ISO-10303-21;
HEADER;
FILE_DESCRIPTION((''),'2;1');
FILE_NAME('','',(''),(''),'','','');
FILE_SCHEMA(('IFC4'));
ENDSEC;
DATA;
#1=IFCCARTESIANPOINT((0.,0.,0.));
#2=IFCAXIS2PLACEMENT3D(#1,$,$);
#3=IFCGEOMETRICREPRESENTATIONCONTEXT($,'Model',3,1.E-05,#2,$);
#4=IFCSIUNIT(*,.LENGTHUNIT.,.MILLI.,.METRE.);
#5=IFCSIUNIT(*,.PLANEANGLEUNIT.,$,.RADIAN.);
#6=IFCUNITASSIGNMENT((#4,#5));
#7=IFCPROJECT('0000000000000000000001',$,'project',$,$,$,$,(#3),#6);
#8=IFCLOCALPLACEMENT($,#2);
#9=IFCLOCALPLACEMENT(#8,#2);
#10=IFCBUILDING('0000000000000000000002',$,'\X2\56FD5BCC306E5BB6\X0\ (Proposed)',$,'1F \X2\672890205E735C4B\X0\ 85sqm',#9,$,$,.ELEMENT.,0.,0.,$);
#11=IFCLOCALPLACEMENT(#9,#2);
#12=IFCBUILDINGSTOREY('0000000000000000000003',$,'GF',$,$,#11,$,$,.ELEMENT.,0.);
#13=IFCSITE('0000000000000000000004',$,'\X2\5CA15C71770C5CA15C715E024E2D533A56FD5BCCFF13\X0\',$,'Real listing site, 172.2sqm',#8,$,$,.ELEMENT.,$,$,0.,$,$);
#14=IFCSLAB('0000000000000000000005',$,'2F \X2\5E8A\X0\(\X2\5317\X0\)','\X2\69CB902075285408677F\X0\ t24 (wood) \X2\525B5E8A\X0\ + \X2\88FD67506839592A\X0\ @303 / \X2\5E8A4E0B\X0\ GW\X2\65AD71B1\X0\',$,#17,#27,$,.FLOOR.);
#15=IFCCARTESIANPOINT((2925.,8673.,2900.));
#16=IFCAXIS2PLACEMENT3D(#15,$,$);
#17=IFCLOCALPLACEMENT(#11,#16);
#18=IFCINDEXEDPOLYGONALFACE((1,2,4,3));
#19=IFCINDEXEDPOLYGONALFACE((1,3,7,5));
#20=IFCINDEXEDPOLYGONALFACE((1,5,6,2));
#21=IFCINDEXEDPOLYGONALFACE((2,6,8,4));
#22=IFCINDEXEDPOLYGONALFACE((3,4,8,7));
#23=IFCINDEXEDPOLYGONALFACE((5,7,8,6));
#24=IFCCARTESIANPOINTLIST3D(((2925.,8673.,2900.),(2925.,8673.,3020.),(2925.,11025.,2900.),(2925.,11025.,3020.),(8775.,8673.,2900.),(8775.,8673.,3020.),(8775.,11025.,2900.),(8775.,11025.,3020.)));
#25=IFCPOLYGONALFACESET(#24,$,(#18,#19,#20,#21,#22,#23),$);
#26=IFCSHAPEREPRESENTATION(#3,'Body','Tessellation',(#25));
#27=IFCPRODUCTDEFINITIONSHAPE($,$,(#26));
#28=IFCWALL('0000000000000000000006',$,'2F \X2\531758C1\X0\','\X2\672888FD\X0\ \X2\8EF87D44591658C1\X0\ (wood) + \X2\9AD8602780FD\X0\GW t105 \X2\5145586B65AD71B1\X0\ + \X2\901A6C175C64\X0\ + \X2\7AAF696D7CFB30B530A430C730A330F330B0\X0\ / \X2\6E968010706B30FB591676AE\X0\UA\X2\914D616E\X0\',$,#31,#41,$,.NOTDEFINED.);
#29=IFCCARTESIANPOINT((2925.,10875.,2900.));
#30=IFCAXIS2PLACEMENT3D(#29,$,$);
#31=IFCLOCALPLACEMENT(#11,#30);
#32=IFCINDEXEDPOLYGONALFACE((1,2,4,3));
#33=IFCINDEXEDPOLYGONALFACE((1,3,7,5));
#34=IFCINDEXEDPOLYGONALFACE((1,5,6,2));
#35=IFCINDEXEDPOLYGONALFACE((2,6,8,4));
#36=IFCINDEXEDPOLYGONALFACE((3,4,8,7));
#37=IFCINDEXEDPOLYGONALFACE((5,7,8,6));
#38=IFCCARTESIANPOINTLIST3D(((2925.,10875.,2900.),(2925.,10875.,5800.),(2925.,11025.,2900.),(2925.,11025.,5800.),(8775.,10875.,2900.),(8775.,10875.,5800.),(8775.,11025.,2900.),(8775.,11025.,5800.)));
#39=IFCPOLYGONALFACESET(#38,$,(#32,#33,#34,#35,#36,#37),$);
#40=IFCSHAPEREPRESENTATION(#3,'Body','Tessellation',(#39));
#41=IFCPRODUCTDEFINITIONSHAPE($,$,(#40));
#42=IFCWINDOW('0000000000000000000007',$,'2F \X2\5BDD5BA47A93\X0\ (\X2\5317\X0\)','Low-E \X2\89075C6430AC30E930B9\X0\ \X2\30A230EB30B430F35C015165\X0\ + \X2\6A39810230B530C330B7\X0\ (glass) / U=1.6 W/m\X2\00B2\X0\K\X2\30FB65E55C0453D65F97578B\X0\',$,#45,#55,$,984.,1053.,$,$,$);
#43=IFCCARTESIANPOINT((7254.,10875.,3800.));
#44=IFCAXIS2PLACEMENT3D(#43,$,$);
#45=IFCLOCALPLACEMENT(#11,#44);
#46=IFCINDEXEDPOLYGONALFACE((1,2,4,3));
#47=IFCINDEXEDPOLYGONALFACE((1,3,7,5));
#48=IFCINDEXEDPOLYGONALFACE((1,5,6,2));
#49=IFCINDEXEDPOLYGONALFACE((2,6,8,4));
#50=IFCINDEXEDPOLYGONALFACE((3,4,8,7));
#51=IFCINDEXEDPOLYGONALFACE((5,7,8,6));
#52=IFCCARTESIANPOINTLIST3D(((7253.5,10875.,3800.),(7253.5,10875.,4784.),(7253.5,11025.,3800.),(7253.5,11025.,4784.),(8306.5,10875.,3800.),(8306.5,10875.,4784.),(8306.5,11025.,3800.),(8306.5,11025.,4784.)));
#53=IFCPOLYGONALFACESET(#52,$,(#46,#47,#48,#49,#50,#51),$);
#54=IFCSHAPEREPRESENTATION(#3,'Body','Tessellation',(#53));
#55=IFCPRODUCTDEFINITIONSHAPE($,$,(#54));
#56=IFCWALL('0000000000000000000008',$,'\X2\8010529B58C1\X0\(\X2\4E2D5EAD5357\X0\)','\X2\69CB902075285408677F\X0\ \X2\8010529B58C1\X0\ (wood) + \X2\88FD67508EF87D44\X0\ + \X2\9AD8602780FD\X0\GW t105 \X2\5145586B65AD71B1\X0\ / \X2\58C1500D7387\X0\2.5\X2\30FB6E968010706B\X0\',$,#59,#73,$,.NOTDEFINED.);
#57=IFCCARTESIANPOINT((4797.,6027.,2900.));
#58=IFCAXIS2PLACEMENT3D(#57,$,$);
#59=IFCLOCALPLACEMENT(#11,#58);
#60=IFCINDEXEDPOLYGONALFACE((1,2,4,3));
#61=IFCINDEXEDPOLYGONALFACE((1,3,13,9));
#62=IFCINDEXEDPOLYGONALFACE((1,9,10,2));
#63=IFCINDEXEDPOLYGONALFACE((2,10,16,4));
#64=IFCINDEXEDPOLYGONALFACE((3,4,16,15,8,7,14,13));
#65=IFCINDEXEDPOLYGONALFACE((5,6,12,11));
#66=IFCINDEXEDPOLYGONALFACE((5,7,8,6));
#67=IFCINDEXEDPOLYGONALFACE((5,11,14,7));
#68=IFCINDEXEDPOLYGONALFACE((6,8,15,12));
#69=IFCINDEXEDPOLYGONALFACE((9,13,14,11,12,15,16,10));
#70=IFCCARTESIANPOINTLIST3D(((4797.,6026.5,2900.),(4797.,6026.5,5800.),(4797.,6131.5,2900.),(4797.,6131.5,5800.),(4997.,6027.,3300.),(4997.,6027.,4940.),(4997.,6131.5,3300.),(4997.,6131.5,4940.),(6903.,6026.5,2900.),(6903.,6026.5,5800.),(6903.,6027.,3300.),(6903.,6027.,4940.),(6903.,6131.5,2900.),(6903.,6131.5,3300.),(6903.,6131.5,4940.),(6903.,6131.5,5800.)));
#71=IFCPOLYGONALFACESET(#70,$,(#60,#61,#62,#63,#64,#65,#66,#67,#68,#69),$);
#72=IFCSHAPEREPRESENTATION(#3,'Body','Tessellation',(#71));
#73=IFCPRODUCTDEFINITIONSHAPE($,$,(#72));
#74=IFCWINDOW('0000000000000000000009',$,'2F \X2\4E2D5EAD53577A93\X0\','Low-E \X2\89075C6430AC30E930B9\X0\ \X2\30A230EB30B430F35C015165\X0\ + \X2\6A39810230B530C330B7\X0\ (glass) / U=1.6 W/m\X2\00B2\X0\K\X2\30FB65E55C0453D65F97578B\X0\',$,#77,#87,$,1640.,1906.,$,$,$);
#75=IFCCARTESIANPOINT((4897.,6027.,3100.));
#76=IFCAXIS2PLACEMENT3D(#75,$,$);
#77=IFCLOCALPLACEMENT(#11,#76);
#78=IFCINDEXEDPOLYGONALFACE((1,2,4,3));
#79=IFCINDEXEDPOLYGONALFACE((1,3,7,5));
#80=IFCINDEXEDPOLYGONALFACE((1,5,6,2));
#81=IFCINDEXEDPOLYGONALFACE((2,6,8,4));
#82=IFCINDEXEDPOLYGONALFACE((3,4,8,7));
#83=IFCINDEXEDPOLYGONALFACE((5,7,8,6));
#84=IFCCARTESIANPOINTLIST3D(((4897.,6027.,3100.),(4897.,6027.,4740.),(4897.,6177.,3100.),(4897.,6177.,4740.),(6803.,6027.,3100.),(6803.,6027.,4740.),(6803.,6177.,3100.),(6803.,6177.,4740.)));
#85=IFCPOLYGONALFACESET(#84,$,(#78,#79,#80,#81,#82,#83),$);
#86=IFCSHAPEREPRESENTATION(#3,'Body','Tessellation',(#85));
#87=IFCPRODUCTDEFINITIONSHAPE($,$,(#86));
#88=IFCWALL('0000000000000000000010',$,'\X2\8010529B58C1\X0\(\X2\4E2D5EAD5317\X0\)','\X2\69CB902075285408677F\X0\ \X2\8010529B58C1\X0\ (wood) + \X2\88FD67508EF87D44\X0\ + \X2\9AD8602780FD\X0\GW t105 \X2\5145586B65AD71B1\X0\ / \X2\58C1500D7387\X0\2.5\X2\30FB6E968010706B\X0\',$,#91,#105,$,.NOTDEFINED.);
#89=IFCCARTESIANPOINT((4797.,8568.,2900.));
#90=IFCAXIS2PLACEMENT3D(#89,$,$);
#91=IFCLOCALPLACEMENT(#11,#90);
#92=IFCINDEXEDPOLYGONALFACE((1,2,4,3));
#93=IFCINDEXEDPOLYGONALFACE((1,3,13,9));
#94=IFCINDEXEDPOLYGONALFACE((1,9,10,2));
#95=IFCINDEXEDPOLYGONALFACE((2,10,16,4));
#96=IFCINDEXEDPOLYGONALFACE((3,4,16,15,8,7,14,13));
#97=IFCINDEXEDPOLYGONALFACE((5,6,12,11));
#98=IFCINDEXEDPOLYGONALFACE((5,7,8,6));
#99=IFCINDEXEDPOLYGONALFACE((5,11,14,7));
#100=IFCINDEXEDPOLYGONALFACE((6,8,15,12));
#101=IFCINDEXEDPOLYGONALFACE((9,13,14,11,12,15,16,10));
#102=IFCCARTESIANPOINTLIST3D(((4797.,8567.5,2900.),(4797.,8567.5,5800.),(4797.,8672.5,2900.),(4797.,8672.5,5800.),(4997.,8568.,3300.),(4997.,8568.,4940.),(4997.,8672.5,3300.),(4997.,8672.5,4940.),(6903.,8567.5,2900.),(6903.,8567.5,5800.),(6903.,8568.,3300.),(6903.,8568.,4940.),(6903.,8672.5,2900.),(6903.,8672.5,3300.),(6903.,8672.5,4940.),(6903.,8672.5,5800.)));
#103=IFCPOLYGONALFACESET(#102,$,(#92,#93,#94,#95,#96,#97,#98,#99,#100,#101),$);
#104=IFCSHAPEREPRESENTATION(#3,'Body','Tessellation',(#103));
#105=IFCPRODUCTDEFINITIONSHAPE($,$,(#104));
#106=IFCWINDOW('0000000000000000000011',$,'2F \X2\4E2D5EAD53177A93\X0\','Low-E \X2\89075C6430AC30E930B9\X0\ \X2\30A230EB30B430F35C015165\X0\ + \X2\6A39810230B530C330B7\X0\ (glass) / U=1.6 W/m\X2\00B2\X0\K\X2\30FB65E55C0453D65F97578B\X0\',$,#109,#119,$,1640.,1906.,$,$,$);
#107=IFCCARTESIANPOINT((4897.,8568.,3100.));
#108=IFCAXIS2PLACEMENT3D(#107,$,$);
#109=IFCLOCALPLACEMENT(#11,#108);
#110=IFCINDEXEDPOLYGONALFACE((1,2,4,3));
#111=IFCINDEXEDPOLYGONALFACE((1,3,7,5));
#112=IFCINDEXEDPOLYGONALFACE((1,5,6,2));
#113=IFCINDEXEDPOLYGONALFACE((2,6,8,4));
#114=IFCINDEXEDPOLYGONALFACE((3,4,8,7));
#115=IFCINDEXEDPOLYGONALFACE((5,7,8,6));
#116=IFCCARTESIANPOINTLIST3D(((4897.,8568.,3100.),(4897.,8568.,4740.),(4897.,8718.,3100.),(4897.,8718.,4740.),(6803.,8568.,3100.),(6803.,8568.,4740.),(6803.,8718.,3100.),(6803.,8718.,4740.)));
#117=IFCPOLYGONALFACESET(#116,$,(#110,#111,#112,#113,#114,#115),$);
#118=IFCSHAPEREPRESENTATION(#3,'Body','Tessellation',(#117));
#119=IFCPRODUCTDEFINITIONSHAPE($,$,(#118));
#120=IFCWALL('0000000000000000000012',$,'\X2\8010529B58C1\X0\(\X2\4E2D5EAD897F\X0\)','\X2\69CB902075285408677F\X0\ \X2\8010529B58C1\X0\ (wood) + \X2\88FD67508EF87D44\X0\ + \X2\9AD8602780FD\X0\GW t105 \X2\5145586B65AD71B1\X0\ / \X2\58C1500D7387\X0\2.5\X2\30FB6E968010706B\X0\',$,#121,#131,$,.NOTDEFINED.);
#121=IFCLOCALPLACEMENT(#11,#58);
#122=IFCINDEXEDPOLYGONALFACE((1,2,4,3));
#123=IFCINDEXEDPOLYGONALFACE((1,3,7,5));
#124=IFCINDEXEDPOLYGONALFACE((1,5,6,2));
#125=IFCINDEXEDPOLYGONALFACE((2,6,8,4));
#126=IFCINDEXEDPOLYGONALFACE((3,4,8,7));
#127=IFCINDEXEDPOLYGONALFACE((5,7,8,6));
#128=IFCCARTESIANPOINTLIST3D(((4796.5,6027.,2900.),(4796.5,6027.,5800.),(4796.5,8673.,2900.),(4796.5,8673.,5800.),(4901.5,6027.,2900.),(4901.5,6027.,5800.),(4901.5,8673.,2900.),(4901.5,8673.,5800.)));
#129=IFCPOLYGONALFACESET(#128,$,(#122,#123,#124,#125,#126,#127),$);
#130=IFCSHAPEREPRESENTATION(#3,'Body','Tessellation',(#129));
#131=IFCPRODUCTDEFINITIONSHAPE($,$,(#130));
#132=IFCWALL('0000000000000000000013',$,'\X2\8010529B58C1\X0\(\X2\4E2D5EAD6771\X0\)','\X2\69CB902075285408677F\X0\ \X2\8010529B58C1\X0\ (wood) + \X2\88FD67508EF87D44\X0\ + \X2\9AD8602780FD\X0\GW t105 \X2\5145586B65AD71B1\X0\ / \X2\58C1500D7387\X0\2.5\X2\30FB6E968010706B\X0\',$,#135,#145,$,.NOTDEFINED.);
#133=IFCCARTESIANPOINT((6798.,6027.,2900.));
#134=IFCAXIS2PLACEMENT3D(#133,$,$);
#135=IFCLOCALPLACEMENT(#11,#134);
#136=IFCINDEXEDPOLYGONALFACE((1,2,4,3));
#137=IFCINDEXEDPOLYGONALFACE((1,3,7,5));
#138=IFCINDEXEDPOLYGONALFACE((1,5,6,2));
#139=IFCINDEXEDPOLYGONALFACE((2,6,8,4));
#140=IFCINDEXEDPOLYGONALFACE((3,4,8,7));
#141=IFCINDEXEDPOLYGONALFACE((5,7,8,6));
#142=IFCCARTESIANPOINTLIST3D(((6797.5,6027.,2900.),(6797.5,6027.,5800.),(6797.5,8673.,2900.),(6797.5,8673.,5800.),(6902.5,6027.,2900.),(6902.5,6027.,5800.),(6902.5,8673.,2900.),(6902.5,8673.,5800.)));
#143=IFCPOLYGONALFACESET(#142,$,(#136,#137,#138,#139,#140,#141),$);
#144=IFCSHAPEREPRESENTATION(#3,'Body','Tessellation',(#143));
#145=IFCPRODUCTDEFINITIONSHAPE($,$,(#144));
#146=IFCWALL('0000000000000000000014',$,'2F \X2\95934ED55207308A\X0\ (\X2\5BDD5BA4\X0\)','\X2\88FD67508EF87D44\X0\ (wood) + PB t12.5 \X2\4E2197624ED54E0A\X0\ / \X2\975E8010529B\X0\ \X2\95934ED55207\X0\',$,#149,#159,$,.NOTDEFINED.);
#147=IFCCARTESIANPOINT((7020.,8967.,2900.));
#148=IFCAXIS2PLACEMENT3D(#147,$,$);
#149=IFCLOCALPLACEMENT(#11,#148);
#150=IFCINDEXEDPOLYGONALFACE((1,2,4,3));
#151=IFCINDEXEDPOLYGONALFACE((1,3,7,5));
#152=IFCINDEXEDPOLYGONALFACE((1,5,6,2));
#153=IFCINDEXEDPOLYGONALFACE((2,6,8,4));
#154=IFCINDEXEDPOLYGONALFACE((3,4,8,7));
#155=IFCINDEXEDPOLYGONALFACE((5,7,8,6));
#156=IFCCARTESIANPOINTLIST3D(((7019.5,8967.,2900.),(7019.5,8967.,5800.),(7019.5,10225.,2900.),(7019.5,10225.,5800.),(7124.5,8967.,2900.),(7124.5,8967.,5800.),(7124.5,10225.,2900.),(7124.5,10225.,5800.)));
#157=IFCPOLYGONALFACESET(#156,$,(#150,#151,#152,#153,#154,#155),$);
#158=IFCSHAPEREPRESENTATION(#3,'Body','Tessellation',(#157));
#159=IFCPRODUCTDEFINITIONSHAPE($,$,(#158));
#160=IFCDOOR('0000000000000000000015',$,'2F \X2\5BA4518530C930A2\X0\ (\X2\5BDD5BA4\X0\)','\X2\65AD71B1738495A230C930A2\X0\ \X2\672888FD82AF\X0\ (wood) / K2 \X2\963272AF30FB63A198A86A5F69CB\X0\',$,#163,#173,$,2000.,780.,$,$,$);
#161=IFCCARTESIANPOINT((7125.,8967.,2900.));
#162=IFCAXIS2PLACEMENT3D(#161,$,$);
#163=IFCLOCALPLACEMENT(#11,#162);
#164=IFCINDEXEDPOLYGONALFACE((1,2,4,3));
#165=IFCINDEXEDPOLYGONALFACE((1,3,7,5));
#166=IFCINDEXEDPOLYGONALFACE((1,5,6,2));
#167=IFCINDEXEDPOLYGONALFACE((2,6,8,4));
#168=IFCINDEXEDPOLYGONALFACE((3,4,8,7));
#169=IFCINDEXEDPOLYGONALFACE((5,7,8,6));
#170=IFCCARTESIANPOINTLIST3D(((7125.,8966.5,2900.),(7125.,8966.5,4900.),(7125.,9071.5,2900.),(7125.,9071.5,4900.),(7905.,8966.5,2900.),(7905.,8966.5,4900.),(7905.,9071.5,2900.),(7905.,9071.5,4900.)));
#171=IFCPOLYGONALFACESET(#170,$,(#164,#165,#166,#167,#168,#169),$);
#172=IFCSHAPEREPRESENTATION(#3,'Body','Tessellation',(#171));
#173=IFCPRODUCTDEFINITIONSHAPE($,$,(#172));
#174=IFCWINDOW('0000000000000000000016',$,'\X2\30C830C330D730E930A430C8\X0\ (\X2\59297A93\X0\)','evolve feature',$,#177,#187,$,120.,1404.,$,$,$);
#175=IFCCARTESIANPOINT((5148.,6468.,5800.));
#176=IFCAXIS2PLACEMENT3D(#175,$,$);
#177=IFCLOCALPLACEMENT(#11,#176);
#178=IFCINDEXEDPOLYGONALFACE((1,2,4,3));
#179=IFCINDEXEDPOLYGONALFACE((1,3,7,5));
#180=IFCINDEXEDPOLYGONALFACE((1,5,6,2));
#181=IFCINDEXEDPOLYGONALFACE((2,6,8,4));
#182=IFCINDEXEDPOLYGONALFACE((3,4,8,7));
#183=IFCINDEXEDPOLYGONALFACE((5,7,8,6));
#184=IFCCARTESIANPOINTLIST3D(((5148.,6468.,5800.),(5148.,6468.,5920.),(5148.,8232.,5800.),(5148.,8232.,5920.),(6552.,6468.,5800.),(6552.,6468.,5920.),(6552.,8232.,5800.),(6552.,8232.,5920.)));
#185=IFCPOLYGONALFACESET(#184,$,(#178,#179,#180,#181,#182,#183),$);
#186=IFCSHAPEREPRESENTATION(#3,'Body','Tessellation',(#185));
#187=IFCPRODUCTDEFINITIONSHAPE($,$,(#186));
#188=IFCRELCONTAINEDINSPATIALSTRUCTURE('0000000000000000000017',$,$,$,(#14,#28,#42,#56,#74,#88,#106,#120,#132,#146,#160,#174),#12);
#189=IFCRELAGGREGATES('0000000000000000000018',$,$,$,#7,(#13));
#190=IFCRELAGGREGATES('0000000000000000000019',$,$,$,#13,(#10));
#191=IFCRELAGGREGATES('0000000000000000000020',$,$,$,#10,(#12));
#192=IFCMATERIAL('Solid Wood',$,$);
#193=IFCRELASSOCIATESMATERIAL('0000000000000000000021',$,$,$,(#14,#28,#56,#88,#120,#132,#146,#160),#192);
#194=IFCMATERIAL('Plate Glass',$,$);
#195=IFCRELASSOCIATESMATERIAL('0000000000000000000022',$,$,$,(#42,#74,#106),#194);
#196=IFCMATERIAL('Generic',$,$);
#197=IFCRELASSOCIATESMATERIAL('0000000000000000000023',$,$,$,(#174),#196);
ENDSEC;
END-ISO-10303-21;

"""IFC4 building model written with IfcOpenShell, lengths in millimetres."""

from ifc_helpers import new_model, si_unit, frame, frame_2d, origin, place, context, project, spatial, rectangle, extrude, material, element, fill, save


model = new_model("IFC4")

# Units and contexts
model_context = context("Model", 3, precision=1e-05, world=origin())
ifc_project = project(units=[si_unit("LENGTHUNIT", "METRE", prefix="MILLI"), si_unit("PLANEANGLEUNIT", "RADIAN")], contexts=[model_context])

# Site, building, storey
site_placement = place(None, origin())
site = spatial("IfcSite", under=ifc_project, at=site_placement, Name="岡山県岡山市中区国富３", ObjectType="Real listing site, 172.2sqm", CompositionType="ELEMENT", RefElevation=0.0)
building_placement = place(site_placement, origin())
building = spatial("IfcBuilding", under=site, at=building_placement, Name="国富の家 (Proposed)", ObjectType="1F 木造平屋 85sqm", CompositionType="ELEMENT", ElevationOfRefHeight=0.0, ElevationOfTerrain=0.0)
storey_placement = place(building_placement, origin())
storey = spatial("IfcBuildingStorey", under=building, at=storey_placement, Name="GF", CompositionType="ELEMENT", Elevation=0.0)

# Slab
ifc_material_1 = material(Name="Solid Wood")
slab_placement = place(storey_placement, frame((2925.0, 8673.0, 2900.0)))
element("IfcSlab", 1, at=slab_placement, inside=storey, material=ifc_material_1, Name="2F 床(北)", Description="構造用合板 t24 (wood) 剛床 + 製材根太 @303 / 床下 GW断熱", PredefinedType="FLOOR", context=model_context, shape_type="SweptSolid", body=[
    extrude(rectangle(XDim=5850.0, YDim=2352.0, at=frame_2d((2925.0, 1176.0))), frame((2925.0, 8673.0, 2900.0)), (0.0, 0.0, 1.0), 120.0),
])

# Walls, openings, windows
wall_1_placement = place(storey_placement, frame((2925.0, 10875.0, 2900.0)))
wall_1 = element("IfcWall", 2, at=wall_1_placement, inside=storey, material=ifc_material_1, Name="2F 北壁", Description="木製 軸組外壁 (wood) + 高性能GW t105 充填断熱 + 通気層 + 窯業系サイディング / 準耐火・外皮UA配慮", PredefinedType="NOTDEFINED", context=model_context, shape_type="SweptSolid", body=[
    extrude(rectangle(XDim=5850.0, YDim=150.0, at=frame_2d((2925.0, 75.0))), frame((2925.0, 10875.0, 2900.0)), (0.0, 0.0, 1.0), 2900.0),
])
opening_1_placement = place(storey_placement, frame((7254.0, 10875.0, 3800.0)))
opening_1 = element("IfcOpeningElement", 3, at=opening_1_placement, cuts=wall_1, PredefinedType="NOTDEFINED", context=model_context, shape_type="SweptSolid", body=[
    extrude(rectangle(XDim=1053.0, YDim=150.0, at=frame_2d((526.0, 75.0))), frame((7254.0, 10875.0, 3800.0)), (0.0, 0.0, 1.0), 984.0),
])
ifc_material_2 = material(Name="Plate Glass")
window_1_placement = place(storey_placement, frame((7254.0, 10875.0, 3800.0)))
window_1 = element("IfcWindow", 4, at=window_1_placement, inside=storey, material=ifc_material_2, Name="2F 寝室窓 (北)", Description="Low-E 複層ガラス アルゴン封入 + 樹脂サッシ (glass) / U=1.6 W/m²K・日射取得型", OverallHeight=984.0, OverallWidth=1053.0, context=model_context, shape_type="SweptSolid", body=[
    extrude(rectangle(XDim=1053.0, YDim=150.0, at=frame_2d((526.0, 75.0))), frame((7254.0, 10875.0, 3800.0)), (0.0, 0.0, 1.0), 984.0),
])
fill(opening_1, window_1)
wall_2_placement = place(storey_placement, frame((4797.0, 6027.0, 2900.0)))
wall_2 = element("IfcWall", 5, at=wall_2_placement, inside=storey, material=ifc_material_1, Name="耐力壁(中庭南)", Description="構造用合板 耐力壁 (wood) + 製材軸組 + 高性能GW t105 充填断熱 / 壁倍率2.5・準耐火", PredefinedType="NOTDEFINED", context=model_context, shape_type="SweptSolid", body=[
    extrude(rectangle(XDim=2106.0, YDim=105.0, at=frame_2d((1053.0, 52.0))), frame((4797.0, 6027.0, 2900.0)), (0.0, 0.0, 1.0), 2900.0),
])
opening_2_placement = place(storey_placement, frame((4897.0, 6027.0, 3100.0)))
opening_2 = element("IfcOpeningElement", 6, at=opening_2_placement, cuts=wall_2, PredefinedType="NOTDEFINED", context=model_context, shape_type="SweptSolid", body=[
    extrude(rectangle(XDim=1906.0, YDim=150.0, at=frame_2d((953.0, 75.0))), frame((4897.0, 6027.0, 3100.0)), (0.0, 0.0, 1.0), 1640.0),
])
window_2_placement = place(storey_placement, frame((4897.0, 6027.0, 3100.0)))
window_2 = element("IfcWindow", 7, at=window_2_placement, inside=storey, material=ifc_material_2, Name="2F 中庭南窓", Description="Low-E 複層ガラス アルゴン封入 + 樹脂サッシ (glass) / U=1.6 W/m²K・日射取得型", OverallHeight=1640.0, OverallWidth=1906.0, context=model_context, shape_type="SweptSolid", body=[
    extrude(rectangle(XDim=1906.0, YDim=150.0, at=frame_2d((953.0, 75.0))), frame((4897.0, 6027.0, 3100.0)), (0.0, 0.0, 1.0), 1640.0),
])
fill(opening_2, window_2)
wall_3_placement = place(storey_placement, frame((4797.0, 8568.0, 2900.0)))
wall_3 = element("IfcWall", 8, at=wall_3_placement, inside=storey, material=ifc_material_1, Name="耐力壁(中庭北)", Description="構造用合板 耐力壁 (wood) + 製材軸組 + 高性能GW t105 充填断熱 / 壁倍率2.5・準耐火", PredefinedType="NOTDEFINED", context=model_context, shape_type="SweptSolid", body=[
    extrude(rectangle(XDim=2106.0, YDim=105.0, at=frame_2d((1053.0, 52.0))), frame((4797.0, 8568.0, 2900.0)), (0.0, 0.0, 1.0), 2900.0),
])
opening_3_placement = place(storey_placement, frame((4897.0, 8568.0, 3100.0)))
opening_3 = element("IfcOpeningElement", 9, at=opening_3_placement, cuts=wall_3, PredefinedType="NOTDEFINED", context=model_context, shape_type="SweptSolid", body=[
    extrude(rectangle(XDim=1906.0, YDim=150.0, at=frame_2d((953.0, 75.0))), frame((4897.0, 8568.0, 3100.0)), (0.0, 0.0, 1.0), 1640.0),
])
window_3_placement = place(storey_placement, frame((4897.0, 8568.0, 3100.0)))
window_3 = element("IfcWindow", 10, at=window_3_placement, inside=storey, material=ifc_material_2, Name="2F 中庭北窓", Description="Low-E 複層ガラス アルゴン封入 + 樹脂サッシ (glass) / U=1.6 W/m²K・日射取得型", OverallHeight=1640.0, OverallWidth=1906.0, context=model_context, shape_type="SweptSolid", body=[
    extrude(rectangle(XDim=1906.0, YDim=150.0, at=frame_2d((953.0, 75.0))), frame((4897.0, 8568.0, 3100.0)), (0.0, 0.0, 1.0), 1640.0),
])
fill(opening_3, window_3)

# Walls
wall_4_placement = place(storey_placement, frame((4797.0, 6027.0, 2900.0)))
element("IfcWall", 11, at=wall_4_placement, inside=storey, material=ifc_material_1, Name="耐力壁(中庭西)", Description="構造用合板 耐力壁 (wood) + 製材軸組 + 高性能GW t105 充填断熱 / 壁倍率2.5・準耐火", PredefinedType="NOTDEFINED", context=model_context, shape_type="SweptSolid", body=[
    extrude(rectangle(XDim=105.0, YDim=2646.0, at=frame_2d((52.0, 1323.0))), frame((4797.0, 6027.0, 2900.0)), (0.0, 0.0, 1.0), 2900.0),
])
wall_5_placement = place(storey_placement, frame((6798.0, 6027.0, 2900.0)))
element("IfcWall", 12, at=wall_5_placement, inside=storey, material=ifc_material_1, Name="耐力壁(中庭東)", Description="構造用合板 耐力壁 (wood) + 製材軸組 + 高性能GW t105 充填断熱 / 壁倍率2.5・準耐火", PredefinedType="NOTDEFINED", context=model_context, shape_type="SweptSolid", body=[
    extrude(rectangle(XDim=105.0, YDim=2646.0, at=frame_2d((52.0, 1323.0))), frame((6798.0, 6027.0, 2900.0)), (0.0, 0.0, 1.0), 2900.0),
])
wall_6_placement = place(storey_placement, frame((7020.0, 8967.0, 2900.0)))
element("IfcWall", 13, at=wall_6_placement, inside=storey, material=ifc_material_1, Name="2F 間仕切り (寝室)", Description="製材軸組 (wood) + PB t12.5 両面仕上 / 非耐力 間仕切", PredefinedType="NOTDEFINED", context=model_context, shape_type="SweptSolid", body=[
    extrude(rectangle(XDim=105.0, YDim=1258.0, at=frame_2d((52.0, 629.0))), frame((7020.0, 8967.0, 2900.0)), (0.0, 0.0, 1.0), 2900.0),
])

# Door
door_placement = place(storey_placement, frame((7125.0, 8967.0, 2900.0)))
element("IfcDoor", 14, at=door_placement, inside=storey, material=ifc_material_1, Name="2F 室内ドア (寝室)", Description="断熱玄関ドア 木製芯 (wood) / K2 防犯・採風機構", OverallHeight=2000.0, OverallWidth=780.0, context=model_context, shape_type="SweptSolid", body=[
    extrude(rectangle(XDim=780.0, YDim=105.0, at=frame_2d((390.0, 52.0))), frame((7125.0, 8967.0, 2900.0)), (0.0, 0.0, 1.0), 2000.0),
])

# Window
ifc_material_3 = material(Name="Generic")
window_4_placement = place(storey_placement, frame((5148.0, 6468.0, 5800.0)))
element("IfcWindow", 15, at=window_4_placement, inside=storey, material=ifc_material_3, Name="トップライト (天窓)", Description="evolve feature", OverallHeight=120.0, OverallWidth=1404.0, context=model_context, shape_type="SweptSolid", body=[
    extrude(rectangle(XDim=1404.0, YDim=1764.0, at=frame_2d((702.0, 882.0))), frame((5148.0, 6468.0, 5800.0)), (0.0, 0.0, 1.0), 120.0),
])

save(model, "model.ifc")
